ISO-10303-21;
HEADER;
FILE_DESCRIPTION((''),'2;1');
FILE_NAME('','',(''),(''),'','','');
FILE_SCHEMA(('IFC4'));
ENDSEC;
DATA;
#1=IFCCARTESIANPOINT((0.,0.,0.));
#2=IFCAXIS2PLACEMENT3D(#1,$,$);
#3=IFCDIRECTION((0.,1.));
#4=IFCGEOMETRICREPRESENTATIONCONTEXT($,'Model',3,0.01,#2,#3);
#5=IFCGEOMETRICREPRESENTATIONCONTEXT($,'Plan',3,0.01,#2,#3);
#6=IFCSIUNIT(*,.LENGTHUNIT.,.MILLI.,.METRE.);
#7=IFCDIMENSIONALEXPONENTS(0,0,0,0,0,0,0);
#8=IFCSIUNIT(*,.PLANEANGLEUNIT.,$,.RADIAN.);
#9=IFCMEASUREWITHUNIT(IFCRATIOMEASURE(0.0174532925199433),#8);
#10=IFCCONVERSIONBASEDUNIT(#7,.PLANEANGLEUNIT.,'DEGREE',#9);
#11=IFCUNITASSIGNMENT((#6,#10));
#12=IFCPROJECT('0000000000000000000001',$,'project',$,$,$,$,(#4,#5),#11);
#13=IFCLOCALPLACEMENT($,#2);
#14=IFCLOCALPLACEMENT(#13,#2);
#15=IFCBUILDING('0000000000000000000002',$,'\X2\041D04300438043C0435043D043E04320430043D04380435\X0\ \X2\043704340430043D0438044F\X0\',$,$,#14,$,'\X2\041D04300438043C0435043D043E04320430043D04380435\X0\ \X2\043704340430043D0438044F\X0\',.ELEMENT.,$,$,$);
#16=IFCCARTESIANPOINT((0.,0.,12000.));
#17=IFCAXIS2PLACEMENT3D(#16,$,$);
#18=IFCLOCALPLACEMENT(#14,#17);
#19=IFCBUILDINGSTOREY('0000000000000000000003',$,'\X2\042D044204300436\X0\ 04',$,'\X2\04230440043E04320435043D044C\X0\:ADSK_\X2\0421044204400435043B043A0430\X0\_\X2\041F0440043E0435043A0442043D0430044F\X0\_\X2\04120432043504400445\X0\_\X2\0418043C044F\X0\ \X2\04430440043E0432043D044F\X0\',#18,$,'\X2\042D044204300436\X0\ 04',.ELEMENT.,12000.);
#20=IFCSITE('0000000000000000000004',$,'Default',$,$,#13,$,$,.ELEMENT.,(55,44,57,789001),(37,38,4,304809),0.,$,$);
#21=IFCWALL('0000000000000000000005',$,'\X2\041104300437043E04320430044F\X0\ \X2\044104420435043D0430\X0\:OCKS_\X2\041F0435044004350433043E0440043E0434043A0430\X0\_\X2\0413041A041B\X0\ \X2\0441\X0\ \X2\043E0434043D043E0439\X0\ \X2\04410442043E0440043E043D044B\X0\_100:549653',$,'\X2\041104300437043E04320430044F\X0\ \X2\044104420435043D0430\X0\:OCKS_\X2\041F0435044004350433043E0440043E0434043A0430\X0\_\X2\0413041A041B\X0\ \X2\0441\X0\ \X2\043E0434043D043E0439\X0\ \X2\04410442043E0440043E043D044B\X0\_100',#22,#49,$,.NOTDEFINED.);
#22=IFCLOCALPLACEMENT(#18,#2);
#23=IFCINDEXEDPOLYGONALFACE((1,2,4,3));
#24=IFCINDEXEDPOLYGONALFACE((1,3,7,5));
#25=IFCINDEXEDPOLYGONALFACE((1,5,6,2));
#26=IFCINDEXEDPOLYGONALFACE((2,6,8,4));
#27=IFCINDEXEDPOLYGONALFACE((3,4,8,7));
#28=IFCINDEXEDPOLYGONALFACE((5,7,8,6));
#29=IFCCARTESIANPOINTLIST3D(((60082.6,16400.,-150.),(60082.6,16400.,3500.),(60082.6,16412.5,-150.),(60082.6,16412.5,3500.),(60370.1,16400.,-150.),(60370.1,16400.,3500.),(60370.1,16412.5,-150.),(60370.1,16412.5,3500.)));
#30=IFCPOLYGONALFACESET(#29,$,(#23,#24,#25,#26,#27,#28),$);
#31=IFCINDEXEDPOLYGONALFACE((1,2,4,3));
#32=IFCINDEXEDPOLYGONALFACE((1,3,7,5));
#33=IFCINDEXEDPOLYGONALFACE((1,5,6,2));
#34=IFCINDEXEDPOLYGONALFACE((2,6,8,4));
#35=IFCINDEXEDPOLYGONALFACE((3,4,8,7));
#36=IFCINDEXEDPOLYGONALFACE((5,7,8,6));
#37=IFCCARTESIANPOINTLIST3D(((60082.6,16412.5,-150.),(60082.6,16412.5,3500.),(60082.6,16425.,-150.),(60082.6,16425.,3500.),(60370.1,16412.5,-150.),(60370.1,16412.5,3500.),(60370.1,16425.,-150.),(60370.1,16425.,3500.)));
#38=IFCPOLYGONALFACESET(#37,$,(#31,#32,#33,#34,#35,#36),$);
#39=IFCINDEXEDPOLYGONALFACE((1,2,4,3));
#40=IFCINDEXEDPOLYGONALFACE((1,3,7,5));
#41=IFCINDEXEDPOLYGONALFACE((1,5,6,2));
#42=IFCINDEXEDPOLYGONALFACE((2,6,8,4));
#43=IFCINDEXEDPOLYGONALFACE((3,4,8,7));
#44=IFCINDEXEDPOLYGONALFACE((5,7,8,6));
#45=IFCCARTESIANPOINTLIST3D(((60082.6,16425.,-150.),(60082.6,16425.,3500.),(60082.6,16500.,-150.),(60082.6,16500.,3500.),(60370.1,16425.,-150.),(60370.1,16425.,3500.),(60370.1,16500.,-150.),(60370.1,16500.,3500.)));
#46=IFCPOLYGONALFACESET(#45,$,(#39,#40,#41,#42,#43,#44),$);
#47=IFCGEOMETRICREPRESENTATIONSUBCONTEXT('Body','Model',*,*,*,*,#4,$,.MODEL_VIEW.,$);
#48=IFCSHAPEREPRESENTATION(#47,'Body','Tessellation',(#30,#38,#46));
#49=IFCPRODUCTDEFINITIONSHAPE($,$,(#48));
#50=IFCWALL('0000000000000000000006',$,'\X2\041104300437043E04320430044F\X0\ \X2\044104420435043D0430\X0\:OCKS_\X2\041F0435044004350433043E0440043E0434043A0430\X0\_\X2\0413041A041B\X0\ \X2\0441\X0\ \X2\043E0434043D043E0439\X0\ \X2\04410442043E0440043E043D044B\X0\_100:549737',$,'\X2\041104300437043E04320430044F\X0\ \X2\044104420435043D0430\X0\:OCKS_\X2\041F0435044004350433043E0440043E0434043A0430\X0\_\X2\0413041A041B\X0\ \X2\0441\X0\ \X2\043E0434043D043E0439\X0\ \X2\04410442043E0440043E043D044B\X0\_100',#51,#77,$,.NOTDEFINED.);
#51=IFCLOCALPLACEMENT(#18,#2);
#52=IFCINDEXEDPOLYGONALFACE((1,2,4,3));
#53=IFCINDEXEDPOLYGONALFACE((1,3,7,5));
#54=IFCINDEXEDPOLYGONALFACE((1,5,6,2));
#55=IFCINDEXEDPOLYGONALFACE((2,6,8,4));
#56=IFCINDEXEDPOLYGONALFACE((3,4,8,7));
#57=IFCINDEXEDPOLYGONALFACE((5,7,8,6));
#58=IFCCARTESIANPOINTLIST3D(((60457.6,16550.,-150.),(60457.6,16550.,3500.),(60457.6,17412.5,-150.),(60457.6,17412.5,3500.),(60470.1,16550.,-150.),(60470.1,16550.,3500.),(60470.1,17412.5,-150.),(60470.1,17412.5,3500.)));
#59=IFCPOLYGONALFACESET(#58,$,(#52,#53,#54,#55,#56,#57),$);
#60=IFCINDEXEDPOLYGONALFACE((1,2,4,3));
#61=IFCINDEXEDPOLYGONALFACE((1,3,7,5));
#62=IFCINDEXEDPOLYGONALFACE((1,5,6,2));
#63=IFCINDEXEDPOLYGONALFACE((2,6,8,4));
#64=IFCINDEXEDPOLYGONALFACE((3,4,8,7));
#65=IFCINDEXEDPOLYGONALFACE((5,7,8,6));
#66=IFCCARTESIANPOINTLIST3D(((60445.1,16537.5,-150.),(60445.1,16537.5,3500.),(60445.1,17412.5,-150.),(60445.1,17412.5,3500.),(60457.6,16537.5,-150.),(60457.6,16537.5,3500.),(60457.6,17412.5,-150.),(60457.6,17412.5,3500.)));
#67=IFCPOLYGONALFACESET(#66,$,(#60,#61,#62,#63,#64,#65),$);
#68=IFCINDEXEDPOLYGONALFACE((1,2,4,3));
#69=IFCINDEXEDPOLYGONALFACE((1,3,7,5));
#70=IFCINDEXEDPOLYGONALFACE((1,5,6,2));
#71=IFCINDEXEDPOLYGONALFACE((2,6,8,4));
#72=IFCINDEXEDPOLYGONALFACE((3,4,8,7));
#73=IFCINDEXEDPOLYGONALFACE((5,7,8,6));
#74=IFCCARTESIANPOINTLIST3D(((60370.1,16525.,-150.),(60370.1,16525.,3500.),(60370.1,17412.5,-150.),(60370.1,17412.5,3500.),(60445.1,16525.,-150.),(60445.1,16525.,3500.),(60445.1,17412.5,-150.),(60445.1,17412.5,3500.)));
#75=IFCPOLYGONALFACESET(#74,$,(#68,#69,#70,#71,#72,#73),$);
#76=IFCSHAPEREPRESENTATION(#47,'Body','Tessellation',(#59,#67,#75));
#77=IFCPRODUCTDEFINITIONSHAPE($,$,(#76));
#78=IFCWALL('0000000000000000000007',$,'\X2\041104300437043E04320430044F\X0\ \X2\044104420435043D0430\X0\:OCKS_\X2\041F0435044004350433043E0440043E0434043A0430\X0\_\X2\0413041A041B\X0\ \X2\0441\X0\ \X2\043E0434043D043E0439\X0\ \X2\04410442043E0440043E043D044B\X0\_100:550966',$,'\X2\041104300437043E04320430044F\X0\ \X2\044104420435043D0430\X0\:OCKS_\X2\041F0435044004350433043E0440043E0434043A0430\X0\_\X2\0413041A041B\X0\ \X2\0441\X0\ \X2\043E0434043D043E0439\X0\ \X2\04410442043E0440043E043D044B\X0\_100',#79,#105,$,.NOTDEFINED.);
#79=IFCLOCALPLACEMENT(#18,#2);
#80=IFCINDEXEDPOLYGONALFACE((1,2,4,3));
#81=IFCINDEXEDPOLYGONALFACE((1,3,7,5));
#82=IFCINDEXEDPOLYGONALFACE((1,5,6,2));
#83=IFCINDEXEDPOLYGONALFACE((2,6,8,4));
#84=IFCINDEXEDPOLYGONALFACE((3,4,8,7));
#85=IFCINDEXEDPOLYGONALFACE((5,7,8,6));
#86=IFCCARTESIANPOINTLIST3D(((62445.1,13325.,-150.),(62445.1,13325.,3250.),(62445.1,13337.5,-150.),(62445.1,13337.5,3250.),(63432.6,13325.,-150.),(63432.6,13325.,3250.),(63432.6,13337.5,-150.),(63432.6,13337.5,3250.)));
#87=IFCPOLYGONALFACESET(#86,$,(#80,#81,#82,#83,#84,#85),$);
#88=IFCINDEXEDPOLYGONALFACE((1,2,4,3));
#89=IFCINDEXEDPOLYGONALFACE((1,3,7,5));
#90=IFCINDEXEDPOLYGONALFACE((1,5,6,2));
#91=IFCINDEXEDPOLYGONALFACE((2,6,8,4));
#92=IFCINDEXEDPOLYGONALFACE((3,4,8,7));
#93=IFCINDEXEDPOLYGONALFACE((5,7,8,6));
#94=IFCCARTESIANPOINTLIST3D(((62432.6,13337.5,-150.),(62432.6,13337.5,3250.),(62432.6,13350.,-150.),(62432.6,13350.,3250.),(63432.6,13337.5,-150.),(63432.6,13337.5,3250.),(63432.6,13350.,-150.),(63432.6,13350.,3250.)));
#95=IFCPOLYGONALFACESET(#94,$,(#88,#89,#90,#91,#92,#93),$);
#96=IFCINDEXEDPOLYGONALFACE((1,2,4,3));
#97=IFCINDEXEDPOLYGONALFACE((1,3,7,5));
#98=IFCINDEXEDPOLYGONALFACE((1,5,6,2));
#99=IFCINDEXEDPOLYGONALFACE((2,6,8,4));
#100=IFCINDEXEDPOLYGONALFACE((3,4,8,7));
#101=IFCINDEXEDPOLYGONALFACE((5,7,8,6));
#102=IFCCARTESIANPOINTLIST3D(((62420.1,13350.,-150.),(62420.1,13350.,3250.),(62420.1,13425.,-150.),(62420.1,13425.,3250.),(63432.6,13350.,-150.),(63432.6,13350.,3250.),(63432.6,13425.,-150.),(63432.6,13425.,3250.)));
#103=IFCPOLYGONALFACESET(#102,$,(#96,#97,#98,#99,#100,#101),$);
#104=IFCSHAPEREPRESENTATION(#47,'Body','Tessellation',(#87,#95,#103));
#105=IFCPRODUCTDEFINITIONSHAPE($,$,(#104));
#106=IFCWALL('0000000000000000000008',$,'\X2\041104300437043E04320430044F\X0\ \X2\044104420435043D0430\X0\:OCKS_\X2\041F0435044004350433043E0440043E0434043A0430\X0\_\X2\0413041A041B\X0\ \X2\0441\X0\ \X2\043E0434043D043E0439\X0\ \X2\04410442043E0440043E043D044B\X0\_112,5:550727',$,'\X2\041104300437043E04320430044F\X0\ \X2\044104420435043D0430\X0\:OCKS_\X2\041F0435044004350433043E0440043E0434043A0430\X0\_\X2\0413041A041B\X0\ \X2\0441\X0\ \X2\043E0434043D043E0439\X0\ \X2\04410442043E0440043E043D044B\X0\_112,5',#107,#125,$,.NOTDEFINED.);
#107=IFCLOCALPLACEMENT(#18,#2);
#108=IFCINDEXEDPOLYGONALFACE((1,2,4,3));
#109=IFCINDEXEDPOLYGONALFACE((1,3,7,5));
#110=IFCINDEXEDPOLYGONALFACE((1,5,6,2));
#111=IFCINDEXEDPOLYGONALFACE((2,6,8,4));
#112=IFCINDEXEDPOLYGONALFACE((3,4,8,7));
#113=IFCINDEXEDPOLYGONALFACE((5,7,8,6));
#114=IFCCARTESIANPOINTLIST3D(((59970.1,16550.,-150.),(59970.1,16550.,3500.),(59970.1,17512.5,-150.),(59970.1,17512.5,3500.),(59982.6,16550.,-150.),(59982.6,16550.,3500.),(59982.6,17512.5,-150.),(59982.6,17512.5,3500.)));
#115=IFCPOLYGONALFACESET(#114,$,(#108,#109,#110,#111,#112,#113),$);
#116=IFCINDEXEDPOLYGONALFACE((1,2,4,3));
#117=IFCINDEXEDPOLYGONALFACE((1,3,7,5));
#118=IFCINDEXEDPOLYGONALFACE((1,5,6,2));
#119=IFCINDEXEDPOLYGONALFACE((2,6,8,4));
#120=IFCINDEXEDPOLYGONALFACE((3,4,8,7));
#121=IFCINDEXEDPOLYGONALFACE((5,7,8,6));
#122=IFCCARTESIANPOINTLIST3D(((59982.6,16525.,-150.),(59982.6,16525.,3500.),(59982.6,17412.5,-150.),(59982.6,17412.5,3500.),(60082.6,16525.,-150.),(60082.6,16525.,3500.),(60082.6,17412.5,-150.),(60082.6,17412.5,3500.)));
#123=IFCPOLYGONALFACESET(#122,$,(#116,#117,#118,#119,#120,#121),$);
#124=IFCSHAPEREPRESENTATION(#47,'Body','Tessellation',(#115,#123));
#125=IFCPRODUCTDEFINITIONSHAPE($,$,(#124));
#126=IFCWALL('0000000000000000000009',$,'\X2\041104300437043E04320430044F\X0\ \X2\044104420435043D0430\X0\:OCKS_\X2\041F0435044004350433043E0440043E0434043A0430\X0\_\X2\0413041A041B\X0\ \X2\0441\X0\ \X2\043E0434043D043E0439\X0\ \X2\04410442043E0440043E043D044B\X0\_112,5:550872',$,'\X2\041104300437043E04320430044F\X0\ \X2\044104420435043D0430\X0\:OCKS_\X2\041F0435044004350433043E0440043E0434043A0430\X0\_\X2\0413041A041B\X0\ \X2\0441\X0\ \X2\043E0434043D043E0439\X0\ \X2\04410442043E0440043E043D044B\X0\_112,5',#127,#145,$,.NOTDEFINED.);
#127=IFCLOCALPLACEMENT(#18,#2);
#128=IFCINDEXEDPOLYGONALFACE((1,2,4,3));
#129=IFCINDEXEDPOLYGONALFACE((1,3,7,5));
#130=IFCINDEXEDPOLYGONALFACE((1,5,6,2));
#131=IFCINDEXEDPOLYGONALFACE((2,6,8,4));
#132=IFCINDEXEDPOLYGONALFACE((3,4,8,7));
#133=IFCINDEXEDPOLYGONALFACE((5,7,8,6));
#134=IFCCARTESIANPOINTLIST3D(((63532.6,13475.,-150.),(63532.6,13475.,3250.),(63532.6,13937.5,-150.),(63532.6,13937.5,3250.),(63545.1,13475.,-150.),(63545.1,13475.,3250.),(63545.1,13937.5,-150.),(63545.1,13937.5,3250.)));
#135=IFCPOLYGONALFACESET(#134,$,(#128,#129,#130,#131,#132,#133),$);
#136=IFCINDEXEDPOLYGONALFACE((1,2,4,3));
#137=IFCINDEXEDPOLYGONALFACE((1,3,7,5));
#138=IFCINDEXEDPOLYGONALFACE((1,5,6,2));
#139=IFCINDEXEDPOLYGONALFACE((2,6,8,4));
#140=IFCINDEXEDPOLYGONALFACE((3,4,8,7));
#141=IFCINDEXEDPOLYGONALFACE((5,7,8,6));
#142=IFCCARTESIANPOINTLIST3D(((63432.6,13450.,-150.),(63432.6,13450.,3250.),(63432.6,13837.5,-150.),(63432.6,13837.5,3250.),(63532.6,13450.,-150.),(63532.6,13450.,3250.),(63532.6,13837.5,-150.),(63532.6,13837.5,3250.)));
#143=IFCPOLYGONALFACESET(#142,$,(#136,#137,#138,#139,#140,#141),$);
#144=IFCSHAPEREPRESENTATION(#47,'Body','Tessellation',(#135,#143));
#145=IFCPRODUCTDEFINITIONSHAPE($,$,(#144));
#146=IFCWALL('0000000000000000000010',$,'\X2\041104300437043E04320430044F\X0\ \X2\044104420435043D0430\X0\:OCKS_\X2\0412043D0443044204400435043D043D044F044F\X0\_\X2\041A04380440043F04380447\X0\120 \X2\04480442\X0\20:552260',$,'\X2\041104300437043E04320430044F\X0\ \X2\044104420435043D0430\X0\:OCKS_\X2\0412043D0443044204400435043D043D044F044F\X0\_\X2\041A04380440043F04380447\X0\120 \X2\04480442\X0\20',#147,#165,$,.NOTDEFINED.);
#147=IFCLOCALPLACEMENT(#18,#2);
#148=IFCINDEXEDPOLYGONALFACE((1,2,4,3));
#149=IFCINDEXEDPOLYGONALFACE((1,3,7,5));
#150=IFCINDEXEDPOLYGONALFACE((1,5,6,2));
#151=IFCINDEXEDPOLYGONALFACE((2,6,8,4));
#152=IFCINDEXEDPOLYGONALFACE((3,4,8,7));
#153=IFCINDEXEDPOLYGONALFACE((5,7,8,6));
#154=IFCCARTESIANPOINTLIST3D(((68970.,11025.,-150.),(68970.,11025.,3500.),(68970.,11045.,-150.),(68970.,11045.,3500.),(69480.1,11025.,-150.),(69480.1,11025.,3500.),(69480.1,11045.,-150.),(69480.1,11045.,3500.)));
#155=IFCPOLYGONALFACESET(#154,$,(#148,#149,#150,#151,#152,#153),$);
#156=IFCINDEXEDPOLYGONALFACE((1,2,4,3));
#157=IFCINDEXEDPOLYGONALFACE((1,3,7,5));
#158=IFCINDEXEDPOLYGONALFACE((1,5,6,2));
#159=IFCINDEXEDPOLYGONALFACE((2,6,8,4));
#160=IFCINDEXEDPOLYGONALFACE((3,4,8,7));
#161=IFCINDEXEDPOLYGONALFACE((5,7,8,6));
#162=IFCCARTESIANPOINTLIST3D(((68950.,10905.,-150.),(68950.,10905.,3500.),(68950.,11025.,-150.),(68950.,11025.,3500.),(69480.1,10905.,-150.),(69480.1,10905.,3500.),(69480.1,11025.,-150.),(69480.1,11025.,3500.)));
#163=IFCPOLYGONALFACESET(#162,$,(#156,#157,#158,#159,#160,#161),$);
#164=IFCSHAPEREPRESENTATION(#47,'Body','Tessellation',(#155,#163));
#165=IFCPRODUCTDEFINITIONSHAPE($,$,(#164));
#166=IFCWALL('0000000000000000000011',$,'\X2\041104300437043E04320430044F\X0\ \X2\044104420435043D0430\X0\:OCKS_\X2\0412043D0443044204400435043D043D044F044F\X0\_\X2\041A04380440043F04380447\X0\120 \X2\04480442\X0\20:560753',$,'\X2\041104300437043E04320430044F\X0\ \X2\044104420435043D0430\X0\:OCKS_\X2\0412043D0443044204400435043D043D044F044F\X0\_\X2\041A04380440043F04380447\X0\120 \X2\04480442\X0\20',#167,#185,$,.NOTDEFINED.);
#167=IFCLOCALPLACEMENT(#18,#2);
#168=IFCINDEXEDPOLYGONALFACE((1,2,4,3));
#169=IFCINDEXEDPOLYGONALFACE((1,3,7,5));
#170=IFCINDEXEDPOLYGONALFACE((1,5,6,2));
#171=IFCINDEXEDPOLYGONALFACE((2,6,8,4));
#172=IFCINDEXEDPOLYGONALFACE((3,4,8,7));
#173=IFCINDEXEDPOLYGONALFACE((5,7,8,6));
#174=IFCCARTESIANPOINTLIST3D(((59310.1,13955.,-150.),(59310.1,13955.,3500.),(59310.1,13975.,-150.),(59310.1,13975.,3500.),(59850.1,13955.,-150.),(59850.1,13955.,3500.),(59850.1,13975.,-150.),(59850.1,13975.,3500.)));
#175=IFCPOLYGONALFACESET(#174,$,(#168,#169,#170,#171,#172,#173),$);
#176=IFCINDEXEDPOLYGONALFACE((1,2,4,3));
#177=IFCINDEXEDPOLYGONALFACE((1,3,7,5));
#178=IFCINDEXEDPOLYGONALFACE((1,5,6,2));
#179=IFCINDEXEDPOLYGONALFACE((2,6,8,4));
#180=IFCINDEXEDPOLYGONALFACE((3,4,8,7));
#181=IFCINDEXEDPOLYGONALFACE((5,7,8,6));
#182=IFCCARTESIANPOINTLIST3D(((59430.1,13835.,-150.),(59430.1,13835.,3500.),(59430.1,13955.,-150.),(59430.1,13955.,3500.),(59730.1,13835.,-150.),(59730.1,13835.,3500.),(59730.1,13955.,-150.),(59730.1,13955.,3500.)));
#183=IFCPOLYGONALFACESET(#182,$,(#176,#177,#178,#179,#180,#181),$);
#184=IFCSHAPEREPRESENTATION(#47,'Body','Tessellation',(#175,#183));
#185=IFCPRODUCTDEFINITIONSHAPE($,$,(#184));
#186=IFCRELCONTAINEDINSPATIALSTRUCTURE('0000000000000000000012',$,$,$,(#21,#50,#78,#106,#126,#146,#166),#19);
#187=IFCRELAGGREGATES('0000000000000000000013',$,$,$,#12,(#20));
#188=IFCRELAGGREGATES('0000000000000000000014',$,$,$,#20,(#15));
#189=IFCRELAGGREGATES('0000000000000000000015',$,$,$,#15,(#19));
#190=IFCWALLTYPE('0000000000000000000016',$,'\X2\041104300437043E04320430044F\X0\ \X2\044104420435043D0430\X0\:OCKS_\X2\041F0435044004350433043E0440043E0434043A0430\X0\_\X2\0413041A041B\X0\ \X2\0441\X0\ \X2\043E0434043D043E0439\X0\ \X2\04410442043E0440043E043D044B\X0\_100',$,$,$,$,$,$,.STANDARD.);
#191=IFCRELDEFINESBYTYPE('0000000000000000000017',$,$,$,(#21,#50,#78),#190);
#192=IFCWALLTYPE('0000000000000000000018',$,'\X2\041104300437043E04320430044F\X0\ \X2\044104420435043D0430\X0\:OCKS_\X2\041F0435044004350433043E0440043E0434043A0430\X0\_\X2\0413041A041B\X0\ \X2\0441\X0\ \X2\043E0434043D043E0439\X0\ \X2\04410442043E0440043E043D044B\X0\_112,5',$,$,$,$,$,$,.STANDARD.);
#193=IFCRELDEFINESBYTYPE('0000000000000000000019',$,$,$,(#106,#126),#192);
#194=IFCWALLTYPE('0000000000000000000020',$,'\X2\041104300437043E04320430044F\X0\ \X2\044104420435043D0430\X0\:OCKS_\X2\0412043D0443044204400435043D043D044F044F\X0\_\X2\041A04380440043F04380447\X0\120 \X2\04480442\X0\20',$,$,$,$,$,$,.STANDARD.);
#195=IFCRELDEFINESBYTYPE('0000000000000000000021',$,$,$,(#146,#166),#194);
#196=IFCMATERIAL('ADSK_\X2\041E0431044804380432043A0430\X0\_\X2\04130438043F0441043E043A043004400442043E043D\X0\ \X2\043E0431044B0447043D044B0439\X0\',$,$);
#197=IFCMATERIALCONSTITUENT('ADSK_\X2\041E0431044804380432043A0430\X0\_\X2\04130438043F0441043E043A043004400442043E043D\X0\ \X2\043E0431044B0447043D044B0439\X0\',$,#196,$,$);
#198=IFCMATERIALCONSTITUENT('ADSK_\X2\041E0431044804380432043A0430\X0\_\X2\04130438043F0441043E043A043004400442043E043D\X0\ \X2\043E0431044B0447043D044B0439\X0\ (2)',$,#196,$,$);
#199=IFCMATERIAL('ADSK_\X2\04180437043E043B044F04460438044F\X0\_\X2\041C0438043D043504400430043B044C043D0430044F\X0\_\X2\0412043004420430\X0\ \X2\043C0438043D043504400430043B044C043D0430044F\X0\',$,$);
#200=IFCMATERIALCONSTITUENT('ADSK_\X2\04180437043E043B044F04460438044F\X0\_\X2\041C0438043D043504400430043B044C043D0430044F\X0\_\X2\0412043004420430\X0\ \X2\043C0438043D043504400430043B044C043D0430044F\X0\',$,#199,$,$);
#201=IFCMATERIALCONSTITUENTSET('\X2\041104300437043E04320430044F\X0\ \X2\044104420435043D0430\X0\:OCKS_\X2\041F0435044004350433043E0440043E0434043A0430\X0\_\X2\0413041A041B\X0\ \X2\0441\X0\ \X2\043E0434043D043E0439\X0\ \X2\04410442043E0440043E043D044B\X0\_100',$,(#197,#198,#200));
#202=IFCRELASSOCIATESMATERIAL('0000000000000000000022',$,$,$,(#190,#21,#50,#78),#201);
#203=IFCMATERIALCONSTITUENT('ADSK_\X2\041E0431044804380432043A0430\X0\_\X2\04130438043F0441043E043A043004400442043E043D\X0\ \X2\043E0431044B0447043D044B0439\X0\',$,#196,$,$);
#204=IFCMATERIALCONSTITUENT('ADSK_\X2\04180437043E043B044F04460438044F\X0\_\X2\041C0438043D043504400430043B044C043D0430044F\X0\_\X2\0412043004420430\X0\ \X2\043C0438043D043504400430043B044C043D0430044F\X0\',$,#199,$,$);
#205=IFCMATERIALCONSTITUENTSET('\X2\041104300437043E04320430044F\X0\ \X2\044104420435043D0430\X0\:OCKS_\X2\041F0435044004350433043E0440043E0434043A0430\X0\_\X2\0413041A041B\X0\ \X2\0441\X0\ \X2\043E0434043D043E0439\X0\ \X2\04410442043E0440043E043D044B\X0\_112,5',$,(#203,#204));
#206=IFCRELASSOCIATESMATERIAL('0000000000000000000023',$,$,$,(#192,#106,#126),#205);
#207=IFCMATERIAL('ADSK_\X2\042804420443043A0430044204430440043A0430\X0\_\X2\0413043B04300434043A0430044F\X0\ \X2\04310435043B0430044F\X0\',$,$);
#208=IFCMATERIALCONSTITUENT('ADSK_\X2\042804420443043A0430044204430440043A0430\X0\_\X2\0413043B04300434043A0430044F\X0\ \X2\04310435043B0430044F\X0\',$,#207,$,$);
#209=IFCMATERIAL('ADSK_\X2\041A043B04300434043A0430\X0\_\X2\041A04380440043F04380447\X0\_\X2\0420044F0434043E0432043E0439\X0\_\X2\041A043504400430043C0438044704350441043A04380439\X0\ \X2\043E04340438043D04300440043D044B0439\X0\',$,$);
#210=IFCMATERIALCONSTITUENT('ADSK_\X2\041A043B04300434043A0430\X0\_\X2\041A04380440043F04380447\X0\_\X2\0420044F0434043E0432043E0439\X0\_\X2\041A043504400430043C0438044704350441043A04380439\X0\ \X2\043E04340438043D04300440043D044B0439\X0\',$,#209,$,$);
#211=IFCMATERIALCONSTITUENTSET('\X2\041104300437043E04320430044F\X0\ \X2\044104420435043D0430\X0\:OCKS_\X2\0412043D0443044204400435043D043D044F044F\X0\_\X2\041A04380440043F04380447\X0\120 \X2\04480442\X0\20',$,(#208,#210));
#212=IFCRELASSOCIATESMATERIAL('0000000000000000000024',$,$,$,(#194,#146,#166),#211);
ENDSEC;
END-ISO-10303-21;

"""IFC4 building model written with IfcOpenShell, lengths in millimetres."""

from ifc_helpers import new_model, entity, si_unit, converted_unit, direction, frame, origin, place, context, subcontext, project, spatial, indexed_curve, outline, extrude, material, constituent, constituent_set, type_object, element, save


model = new_model("IFC4")

# Units and contexts
model_context = context("Model", 3, precision=0.01, world=origin(), true_north=direction((0.0, 1.0)))
plan_context = context("Plan", 3, precision=0.01, world=origin(), true_north=direction((0.0, 1.0)))
body_context = subcontext(model_context, "Body", "Model", "MODEL_VIEW")
ifc_project = project(units=[si_unit("LENGTHUNIT", "METRE", prefix="MILLI"), converted_unit("PLANEANGLEUNIT", "DEGREE", entity("IfcRatioMeasure", 0.0174532925199433), si_unit("PLANEANGLEUNIT", "RADIAN"), dimensions=[0, 0, 0, 0, 0, 0, 0])], contexts=[model_context, plan_context])

# Site, building, storey
site_placement = place(None, frame((0.0, 0.0, 0.0)))
site = spatial("IfcSite", under=ifc_project, at=site_placement, Name="Default", CompositionType="ELEMENT", RefLatitude=(55, 44, 57, 789001), RefLongitude=(37, 38, 4, 304809), RefElevation=0.0)
building_placement = place(site_placement, origin())
building = spatial("IfcBuilding", under=site, at=building_placement, Name="Наименование здания", LongName="Наименование здания", CompositionType="ELEMENT")
storey_placement = place(building_placement, frame((0.0, 0.0, 12000.0)))
storey = spatial("IfcBuildingStorey", under=building, at=storey_placement, Name="Этаж 04", ObjectType="Уровень:ADSK_Стрелка_Проектная_Вверх_Имя уровня", LongName="Этаж 04", CompositionType="ELEMENT", Elevation=12000.0)

# Shared definitions
ifc_material_1 = material(Name="ADSK_Обшивка_Гипсокартон обычный")
ifc_material_2 = material(Name="ADSK_Изоляция_Минеральная_Вата минеральная")

# Walls
ifc_constituent_1 = constituent(ifc_material_1, Name="ADSK_Обшивка_Гипсокартон обычный")
ifc_constituent_2 = constituent(ifc_material_1, Name="ADSK_Обшивка_Гипсокартон обычный (2)")
ifc_constituent_3 = constituent(ifc_material_2, Name="ADSK_Изоляция_Минеральная_Вата минеральная")
ifc_constituent_set_1 = constituent_set(constituents=[ifc_constituent_1, ifc_constituent_2, ifc_constituent_3], Name="Базовая стена:OCKS_Перегородка_ГКЛ с одной стороны_100")
wall_type_1 = type_object("IfcWallType", Name="Базовая стена:OCKS_Перегородка_ГКЛ с одной стороны_100", PredefinedType="STANDARD", material=ifc_constituent_set_1)
wall_1_placement = place(storey_placement, frame((60082.6, 16450.0, -150.0)))
element("IfcWall", 1, at=wall_1_placement, inside=storey, type_object=wall_type_1, material=ifc_constituent_set_1, Name="Базовая стена:OCKS_Перегородка_ГКЛ с одной стороны_100:549653", ObjectType="Базовая стена:OCKS_Перегородка_ГКЛ с одной стороны_100", PredefinedType="NOTDEFINED", context=body_context, shape_type="SweptSolid", body=[
    extrude(outline(indexed_curve([(-6.2, -143.8), (6.3, -143.8), (6.3, 143.8), (-6.2, 143.8), (-6.2, -143.8)], self_intersect=False)), frame((143.8, -43.8, 0.0), z_axis=(0.0, 0.0, 1.0), x_axis=(0.0, 1.0, 0.0)), (0.0, 0.0, 1.0), 3650.0),
    extrude(outline(indexed_curve([(-143.8, -6.2), (143.8, -6.2), (143.8, 6.3), (-143.8, 6.3), (-143.8, -6.2)], self_intersect=False)), frame((143.8, -31.3, 0.0)), (0.0, 0.0, 1.0), 3650.0),
    extrude(outline(indexed_curve([(-37.5, -143.8), (37.5, -143.8), (37.5, 143.8), (-37.5, 143.8), (-37.5, -143.8)], self_intersect=False)), frame((143.8, 12.5, 0.0), z_axis=(0.0, 0.0, 1.0), x_axis=(0.0, -1.0, 0.0)), (0.0, 0.0, 1.0), 3650.0),
])
wall_2_placement = place(storey_placement, frame((60420.1, 16550.0, -150.0), z_axis=(0.0, 0.0, 1.0), x_axis=(0.0, 1.0, 0.0)))
element("IfcWall", 2, at=wall_2_placement, inside=storey, type_object=wall_type_1, material=ifc_constituent_set_1, Name="Базовая стена:OCKS_Перегородка_ГКЛ с одной стороны_100:549737", ObjectType="Базовая стена:OCKS_Перегородка_ГКЛ с одной стороны_100", PredefinedType="NOTDEFINED", context=body_context, shape_type="SweptSolid", body=[
    extrude(outline(indexed_curve([(-6.3, -431.3), (6.3, -431.3), (6.3, 431.3), (-6.3, 431.3), (-6.3, -431.3)], self_intersect=False)), frame((431.3, -43.8, 0.0), z_axis=(0.0, 0.0, 1.0), x_axis=(0.0, 1.0, 0.0)), (0.0, 0.0, 1.0), 3650.0),
    extrude(outline(indexed_curve([(-437.5, -6.3), (437.5, -6.3), (437.5, 6.2), (-437.5, 6.2), (-437.5, -6.3)], self_intersect=False)), frame((425.0, -31.2, 0.0)), (0.0, 0.0, 1.0), 3650.0),
    extrude(outline(indexed_curve([(-37.5, -443.8), (37.5, -443.8), (37.5, 443.8), (-37.5, 443.8), (-37.5, -443.8)], self_intersect=False)), frame((418.8, 12.5, 0.0), z_axis=(0.0, 0.0, 1.0), x_axis=(0.0, -1.0, 0.0)), (0.0, 0.0, 1.0), 3650.0),
])
wall_3_placement = place(storey_placement, frame((63432.6, 13375.0, -150.0), z_axis=(0.0, 0.0, 1.0), x_axis=(-1.0, 0.0, 0.0)))
element("IfcWall", 3, at=wall_3_placement, inside=storey, type_object=wall_type_1, material=ifc_constituent_set_1, Name="Базовая стена:OCKS_Перегородка_ГКЛ с одной стороны_100:550966", ObjectType="Базовая стена:OCKS_Перегородка_ГКЛ с одной стороны_100", PredefinedType="NOTDEFINED", context=body_context, shape_type="SweptSolid", body=[
    extrude(outline(indexed_curve([(-6.2, -493.8), (6.3, -493.8), (6.3, 493.8), (-6.2, 493.8), (-6.2, -493.8)], self_intersect=False)), frame((493.8, 43.8, 0.0), z_axis=(0.0, 0.0, 1.0), x_axis=(0.0, -1.0, 0.0)), (0.0, 0.0, 1.0), 3400.0),
    extrude(outline(indexed_curve([(-500.0, -6.2), (500.0, -6.2), (500.0, 6.3), (-500.0, 6.3), (-500.0, -6.2)], self_intersect=False)), frame((500.0, 31.2, 0.0)), (0.0, 0.0, 1.0), 3400.0),
    extrude(outline(indexed_curve([(-37.5, -506.3), (37.5, -506.3), (37.5, 506.3), (-37.5, 506.3), (-37.5, -506.3)], self_intersect=False)), frame((506.3, -12.5, 0.0), z_axis=(0.0, 0.0, 1.0), x_axis=(0.0, 1.0, 0.0)), (0.0, 0.0, 1.0), 3400.0),
])
ifc_constituent_4 = constituent(ifc_material_1, Name="ADSK_Обшивка_Гипсокартон обычный")
ifc_constituent_5 = constituent(ifc_material_2, Name="ADSK_Изоляция_Минеральная_Вата минеральная")
ifc_constituent_set_2 = constituent_set(constituents=[ifc_constituent_4, ifc_constituent_5], Name="Базовая стена:OCKS_Перегородка_ГКЛ с одной стороны_112,5")
wall_type_2 = type_object("IfcWallType", Name="Базовая стена:OCKS_Перегородка_ГКЛ с одной стороны_112,5", PredefinedType="STANDARD", material=ifc_constituent_set_2)
wall_4_placement = place(storey_placement, frame((60026.4, 16550.0, -150.0), z_axis=(0.0, 0.0, 1.0), x_axis=(0.0, 1.0, 0.0)))
element("IfcWall", 4, at=wall_4_placement, inside=storey, type_object=wall_type_2, material=ifc_constituent_set_2, Name="Базовая стена:OCKS_Перегородка_ГКЛ с одной стороны_112,5:550727", ObjectType="Базовая стена:OCKS_Перегородка_ГКЛ с одной стороны_112,5", PredefinedType="NOTDEFINED", context=body_context, shape_type="SweptSolid", body=[
    extrude(outline(indexed_curve([(-6.3, -481.3), (6.2, -481.3), (6.2, 481.3), (-6.3, 481.3), (-6.3, -481.3)], self_intersect=False)), frame((481.3, 50.0, 0.0), z_axis=(0.0, 0.0, 1.0), x_axis=(0.0, -1.0, 0.0)), (0.0, 0.0, 1.0), 3650.0),
    extrude(outline(indexed_curve([(-50.0, -443.8), (50.0, -443.8), (50.0, 443.8), (-50.0, 443.8), (-50.0, -443.8)], self_intersect=False)), frame((418.8, -6.2, 0.0), z_axis=(0.0, 0.0, 1.0), x_axis=(0.0, 1.0, 0.0)), (0.0, 0.0, 1.0), 3650.0),
])
wall_5_placement = place(storey_placement, frame((63488.9, 13837.5, -150.0), z_axis=(0.0, 0.0, 1.0), x_axis=(0.0, -1.0, 0.0)))
element("IfcWall", 5, at=wall_5_placement, inside=storey, type_object=wall_type_2, material=ifc_constituent_set_2, Name="Базовая стена:OCKS_Перегородка_ГКЛ с одной стороны_112,5:550872", ObjectType="Базовая стена:OCKS_Перегородка_ГКЛ с одной стороны_112,5", PredefinedType="NOTDEFINED", context=body_context, shape_type="SweptSolid", body=[
    extrude(outline(indexed_curve([(-6.3, -231.2), (6.2, -231.2), (6.2, 231.2), (-6.3, 231.2), (-6.3, -231.2)], self_intersect=False)), frame((131.2, 50.0, 0.0), z_axis=(0.0, 0.0, 1.0), x_axis=(0.0, -1.0, 0.0)), (0.0, 0.0, 1.0), 3400.0),
    extrude(outline(indexed_curve([(-50.0, -193.7), (50.0, -193.7), (50.0, 193.7), (-50.0, 193.7), (-50.0, -193.7)], self_intersect=False)), frame((193.7, -6.2, 0.0), z_axis=(0.0, 0.0, 1.0), x_axis=(0.0, 1.0, 0.0)), (0.0, 0.0, 1.0), 3400.0),
])
ifc_material_3 = material(Name="ADSK_Штукатурка_Гладкая белая")
ifc_constituent_6 = constituent(ifc_material_3, Name="ADSK_Штукатурка_Гладкая белая")
ifc_material_4 = material(Name="ADSK_Кладка_Кирпич_Рядовой_Керамический одинарный")
ifc_constituent_7 = constituent(ifc_material_4, Name="ADSK_Кладка_Кирпич_Рядовой_Керамический одинарный")
ifc_constituent_set_3 = constituent_set(constituents=[ifc_constituent_6, ifc_constituent_7], Name="Базовая стена:OCKS_Внутренняя_Кирпич120 шт20")
wall_type_3 = type_object("IfcWallType", Name="Базовая стена:OCKS_Внутренняя_Кирпич120 шт20", PredefinedType="STANDARD", material=ifc_constituent_set_3)
wall_6_placement = place(storey_placement, frame((68970.0, 10975.0, -150.0)))
element("IfcWall", 6, at=wall_6_placement, inside=storey, type_object=wall_type_3, material=ifc_constituent_set_3, Name="Базовая стена:OCKS_Внутренняя_Кирпич120 шт20:552260", ObjectType="Базовая стена:OCKS_Внутренняя_Кирпич120 шт20", PredefinedType="NOTDEFINED", context=body_context, shape_type="SweptSolid", body=[
    extrude(outline(indexed_curve([(-10.0, -255.0), (10.0, -255.0), (10.0, 255.0), (-10.0, 255.0), (-10.0, -255.0)], self_intersect=False)), frame((255.0, 60.0, 0.0), z_axis=(0.0, 0.0, 1.0), x_axis=(0.0, -1.0, 0.0)), (0.0, 0.0, 1.0), 3650.0),
    extrude(outline(indexed_curve([(-60.0, -265.0), (60.0, -265.0), (60.0, 265.0), (-60.0, 265.0), (-60.0, -265.0)], self_intersect=False)), frame((245.0, -10.0, 0.0), z_axis=(0.0, 0.0, 1.0), x_axis=(0.0, 1.0, 0.0)), (0.0, 0.0, 1.0), 3650.0),
])
wall_7_placement = place(storey_placement, frame((59730.1, 13905.0, -150.0), z_axis=(0.0, 0.0, 1.0), x_axis=(-1.0, 0.0, 0.0)))
element("IfcWall", 7, at=wall_7_placement, inside=storey, type_object=wall_type_3, material=ifc_constituent_set_3, Name="Базовая стена:OCKS_Внутренняя_Кирпич120 шт20:560753", ObjectType="Базовая стена:OCKS_Внутренняя_Кирпич120 шт20", PredefinedType="NOTDEFINED", context=body_context, shape_type="SweptSolid", body=[
    extrude(outline(indexed_curve([(-10.0, -270.0), (10.0, -270.0), (10.0, 270.0), (-10.0, 270.0), (-10.0, -270.0)], self_intersect=False)), frame((150.0, -60.0, 0.0), z_axis=(0.0, 0.0, 1.0), x_axis=(0.0, 1.0, 0.0)), (0.0, 0.0, 1.0), 3650.0),
    extrude(outline(indexed_curve([(-60.0, -150.0), (60.0, -150.0), (60.0, 150.0), (-60.0, 150.0), (-60.0, -150.0)], self_intersect=False)), frame((150.0, 10.0, 0.0), z_axis=(0.0, 0.0, 1.0), x_axis=(0.0, -1.0, 0.0)), (0.0, 0.0, 1.0), 3650.0),
])

save(model, "model.ifc")
